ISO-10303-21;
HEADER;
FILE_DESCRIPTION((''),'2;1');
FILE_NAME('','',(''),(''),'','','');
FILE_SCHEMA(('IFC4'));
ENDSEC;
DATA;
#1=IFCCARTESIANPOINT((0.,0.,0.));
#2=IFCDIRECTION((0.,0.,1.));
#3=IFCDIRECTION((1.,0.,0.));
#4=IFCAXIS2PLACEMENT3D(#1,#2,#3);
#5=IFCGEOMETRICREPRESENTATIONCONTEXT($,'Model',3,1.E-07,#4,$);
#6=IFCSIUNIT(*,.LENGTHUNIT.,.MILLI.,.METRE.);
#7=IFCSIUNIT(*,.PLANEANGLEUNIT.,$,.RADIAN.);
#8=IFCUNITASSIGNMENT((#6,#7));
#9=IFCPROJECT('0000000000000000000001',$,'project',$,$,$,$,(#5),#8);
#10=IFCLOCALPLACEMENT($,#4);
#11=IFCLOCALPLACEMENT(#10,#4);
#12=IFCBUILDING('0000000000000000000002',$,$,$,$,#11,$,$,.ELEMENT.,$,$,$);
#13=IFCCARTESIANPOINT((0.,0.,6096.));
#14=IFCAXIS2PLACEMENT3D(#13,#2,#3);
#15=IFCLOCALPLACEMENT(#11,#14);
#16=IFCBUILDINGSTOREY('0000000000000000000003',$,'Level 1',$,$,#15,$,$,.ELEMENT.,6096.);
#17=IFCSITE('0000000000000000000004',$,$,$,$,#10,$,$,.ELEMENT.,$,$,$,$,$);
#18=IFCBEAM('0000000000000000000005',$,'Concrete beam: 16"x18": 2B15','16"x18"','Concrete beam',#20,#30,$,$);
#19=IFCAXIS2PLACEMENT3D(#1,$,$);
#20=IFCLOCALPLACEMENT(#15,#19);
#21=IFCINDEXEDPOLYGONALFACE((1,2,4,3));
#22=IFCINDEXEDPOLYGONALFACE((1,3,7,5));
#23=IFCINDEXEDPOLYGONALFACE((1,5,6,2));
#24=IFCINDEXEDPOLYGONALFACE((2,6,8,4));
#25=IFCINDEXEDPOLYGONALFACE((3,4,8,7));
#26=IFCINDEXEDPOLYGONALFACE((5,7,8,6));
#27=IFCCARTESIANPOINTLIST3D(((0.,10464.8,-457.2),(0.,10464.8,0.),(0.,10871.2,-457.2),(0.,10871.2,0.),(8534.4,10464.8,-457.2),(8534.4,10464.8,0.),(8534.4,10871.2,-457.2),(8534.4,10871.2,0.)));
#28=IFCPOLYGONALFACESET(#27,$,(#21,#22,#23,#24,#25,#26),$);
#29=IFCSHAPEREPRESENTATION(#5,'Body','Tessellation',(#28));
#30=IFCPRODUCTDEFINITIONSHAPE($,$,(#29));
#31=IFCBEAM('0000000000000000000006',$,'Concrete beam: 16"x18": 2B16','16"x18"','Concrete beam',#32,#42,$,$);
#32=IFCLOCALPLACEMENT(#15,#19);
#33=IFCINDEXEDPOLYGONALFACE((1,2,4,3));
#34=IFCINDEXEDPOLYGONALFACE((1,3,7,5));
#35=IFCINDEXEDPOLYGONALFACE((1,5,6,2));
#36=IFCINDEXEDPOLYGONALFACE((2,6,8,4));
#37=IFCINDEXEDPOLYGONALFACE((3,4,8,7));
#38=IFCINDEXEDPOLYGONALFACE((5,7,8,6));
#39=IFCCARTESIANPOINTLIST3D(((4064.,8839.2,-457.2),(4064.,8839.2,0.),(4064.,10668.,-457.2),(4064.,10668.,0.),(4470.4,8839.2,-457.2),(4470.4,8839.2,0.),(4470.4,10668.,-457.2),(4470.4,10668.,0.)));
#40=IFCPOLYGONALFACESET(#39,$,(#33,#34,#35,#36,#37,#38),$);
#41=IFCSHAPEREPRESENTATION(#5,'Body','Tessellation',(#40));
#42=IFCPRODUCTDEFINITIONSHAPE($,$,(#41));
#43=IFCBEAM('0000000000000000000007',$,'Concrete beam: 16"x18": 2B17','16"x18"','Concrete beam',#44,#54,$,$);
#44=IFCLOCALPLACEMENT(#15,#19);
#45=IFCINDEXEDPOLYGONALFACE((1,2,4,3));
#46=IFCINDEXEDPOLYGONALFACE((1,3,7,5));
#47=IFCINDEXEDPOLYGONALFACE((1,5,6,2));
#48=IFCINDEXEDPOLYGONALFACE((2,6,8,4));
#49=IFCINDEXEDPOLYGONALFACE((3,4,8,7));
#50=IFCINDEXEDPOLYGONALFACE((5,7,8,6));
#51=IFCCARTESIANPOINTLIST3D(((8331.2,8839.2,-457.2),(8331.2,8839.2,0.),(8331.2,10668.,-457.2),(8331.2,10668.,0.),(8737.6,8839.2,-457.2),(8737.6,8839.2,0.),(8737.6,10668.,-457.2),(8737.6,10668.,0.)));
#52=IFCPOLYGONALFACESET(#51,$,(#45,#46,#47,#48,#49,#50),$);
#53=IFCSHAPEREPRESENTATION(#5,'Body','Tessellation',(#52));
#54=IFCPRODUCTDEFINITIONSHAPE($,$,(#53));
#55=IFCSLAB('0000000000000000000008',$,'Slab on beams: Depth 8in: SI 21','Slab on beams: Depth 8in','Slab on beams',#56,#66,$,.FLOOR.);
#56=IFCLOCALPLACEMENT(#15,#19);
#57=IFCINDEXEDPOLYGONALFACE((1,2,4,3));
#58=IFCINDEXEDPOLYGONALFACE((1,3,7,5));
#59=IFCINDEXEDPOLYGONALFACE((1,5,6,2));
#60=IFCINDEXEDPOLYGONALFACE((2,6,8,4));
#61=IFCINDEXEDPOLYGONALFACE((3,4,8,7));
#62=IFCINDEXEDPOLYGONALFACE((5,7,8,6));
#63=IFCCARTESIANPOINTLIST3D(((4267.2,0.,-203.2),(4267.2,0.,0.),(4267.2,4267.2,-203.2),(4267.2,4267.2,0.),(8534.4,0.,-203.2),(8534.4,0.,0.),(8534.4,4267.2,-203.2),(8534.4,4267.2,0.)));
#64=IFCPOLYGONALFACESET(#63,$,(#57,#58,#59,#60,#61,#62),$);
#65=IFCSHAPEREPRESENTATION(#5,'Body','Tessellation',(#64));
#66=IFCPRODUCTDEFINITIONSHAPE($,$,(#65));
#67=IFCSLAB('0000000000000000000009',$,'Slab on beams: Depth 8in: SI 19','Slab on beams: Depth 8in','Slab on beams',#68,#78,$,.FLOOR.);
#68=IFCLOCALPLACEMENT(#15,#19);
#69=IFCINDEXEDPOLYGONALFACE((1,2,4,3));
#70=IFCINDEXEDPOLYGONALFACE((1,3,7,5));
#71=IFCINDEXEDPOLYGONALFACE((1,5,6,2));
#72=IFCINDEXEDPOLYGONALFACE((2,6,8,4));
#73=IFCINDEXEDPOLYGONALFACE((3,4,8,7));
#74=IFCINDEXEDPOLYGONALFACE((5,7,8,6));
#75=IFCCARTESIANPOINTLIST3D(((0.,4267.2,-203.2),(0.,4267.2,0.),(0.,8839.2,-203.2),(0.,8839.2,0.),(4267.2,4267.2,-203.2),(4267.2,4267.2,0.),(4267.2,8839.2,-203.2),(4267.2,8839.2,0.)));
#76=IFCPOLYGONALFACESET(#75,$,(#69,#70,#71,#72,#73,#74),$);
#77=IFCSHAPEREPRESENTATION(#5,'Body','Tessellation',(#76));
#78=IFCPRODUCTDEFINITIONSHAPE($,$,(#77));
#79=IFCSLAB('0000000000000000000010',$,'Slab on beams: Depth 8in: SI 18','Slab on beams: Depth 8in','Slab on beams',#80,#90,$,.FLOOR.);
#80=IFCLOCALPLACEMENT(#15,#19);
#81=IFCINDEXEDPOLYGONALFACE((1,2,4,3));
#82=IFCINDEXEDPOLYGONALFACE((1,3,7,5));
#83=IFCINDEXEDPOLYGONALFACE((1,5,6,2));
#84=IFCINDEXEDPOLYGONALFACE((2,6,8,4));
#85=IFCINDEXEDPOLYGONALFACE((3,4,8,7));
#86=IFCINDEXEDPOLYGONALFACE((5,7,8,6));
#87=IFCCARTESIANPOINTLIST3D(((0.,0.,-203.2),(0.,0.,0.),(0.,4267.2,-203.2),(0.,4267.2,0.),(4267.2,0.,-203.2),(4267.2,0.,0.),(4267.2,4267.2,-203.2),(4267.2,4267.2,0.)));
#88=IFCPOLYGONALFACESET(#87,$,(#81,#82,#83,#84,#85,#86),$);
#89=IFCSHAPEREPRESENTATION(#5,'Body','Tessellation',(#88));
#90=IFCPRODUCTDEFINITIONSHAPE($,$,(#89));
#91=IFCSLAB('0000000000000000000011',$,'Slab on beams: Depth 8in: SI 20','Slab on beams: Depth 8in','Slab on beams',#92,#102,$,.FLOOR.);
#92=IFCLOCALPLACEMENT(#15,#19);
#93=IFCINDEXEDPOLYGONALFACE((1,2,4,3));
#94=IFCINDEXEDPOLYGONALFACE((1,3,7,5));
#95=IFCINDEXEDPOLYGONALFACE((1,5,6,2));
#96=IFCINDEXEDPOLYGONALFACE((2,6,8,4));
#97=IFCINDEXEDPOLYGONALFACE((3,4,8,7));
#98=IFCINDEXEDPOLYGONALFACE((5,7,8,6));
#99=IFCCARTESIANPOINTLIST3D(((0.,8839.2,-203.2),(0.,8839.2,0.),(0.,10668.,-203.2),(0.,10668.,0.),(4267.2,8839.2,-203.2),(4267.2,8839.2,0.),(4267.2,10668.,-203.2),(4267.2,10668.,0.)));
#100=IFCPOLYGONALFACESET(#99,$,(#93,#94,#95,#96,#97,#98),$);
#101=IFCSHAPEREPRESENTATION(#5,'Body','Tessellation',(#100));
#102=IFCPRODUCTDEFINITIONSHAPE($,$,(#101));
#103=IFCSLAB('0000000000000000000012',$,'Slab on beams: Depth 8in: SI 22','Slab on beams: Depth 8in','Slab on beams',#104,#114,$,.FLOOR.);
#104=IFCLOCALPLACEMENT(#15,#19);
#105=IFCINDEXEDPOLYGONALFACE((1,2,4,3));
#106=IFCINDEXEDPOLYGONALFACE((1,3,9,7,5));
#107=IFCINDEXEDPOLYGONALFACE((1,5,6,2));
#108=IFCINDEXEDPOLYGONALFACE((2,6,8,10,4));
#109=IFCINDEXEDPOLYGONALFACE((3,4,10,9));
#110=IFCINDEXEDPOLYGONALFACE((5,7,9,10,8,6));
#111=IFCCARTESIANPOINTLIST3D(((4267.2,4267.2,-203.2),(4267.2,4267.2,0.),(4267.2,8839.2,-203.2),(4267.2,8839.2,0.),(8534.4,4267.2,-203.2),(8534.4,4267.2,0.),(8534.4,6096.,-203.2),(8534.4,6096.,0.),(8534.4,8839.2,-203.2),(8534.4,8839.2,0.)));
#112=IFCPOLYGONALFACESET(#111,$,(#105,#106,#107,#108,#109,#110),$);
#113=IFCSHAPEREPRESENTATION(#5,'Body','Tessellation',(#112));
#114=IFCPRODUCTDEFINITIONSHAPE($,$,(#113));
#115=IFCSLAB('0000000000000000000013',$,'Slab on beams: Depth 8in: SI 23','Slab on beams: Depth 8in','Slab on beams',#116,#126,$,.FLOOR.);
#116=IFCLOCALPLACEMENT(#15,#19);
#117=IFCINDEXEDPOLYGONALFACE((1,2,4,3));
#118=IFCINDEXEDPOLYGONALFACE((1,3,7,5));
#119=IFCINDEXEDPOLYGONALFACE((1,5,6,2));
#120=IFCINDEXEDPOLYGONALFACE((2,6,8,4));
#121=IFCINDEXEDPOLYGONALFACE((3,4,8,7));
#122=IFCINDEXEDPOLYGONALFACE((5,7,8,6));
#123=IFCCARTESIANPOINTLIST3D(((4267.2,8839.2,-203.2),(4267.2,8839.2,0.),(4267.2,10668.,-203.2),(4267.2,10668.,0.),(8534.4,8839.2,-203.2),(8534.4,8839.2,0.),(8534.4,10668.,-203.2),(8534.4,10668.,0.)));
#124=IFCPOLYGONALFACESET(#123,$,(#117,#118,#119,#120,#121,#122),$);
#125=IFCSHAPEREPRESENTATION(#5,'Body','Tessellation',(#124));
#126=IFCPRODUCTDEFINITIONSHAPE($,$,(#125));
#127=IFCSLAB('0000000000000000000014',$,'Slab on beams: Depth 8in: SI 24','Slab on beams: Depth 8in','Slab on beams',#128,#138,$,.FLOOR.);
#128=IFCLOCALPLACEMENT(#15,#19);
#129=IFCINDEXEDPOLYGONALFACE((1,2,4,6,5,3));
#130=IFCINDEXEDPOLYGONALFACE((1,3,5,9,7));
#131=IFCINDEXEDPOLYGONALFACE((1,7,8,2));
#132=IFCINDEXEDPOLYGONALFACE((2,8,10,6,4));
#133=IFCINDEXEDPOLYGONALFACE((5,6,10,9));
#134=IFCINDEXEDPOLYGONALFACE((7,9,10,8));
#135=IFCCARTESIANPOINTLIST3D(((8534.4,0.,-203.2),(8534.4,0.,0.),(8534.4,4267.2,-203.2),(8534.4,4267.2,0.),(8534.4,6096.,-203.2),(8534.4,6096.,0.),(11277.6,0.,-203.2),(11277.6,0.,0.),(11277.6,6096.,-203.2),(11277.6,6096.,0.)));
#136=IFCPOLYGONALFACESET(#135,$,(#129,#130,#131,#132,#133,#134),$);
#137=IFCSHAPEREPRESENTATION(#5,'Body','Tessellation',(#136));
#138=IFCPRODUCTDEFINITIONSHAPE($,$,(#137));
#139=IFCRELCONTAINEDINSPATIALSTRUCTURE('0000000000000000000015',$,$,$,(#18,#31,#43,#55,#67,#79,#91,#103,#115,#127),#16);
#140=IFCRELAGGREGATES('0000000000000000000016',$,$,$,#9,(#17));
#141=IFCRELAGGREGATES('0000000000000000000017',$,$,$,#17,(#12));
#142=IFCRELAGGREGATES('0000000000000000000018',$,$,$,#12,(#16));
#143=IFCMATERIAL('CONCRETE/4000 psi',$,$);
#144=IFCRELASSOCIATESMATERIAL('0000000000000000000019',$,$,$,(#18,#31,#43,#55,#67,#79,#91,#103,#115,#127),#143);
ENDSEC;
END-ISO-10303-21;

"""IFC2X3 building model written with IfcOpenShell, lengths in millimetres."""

from ifc_helpers import new_model, si_unit, frame, origin_with_axes, origin_2d_with_axis, place, context, project, spatial, polyline, segment, composite_curve, rectangle, outline, extrude, material, element, save


model = new_model("IFC2X3")

# Units and contexts
model_context = context("Model", 3, precision=1e-07, world=origin_with_axes())
ifc_project = project(units=[si_unit("LENGTHUNIT", "METRE", prefix="MILLI"), si_unit("PLANEANGLEUNIT", "RADIAN")], contexts=[model_context])

# Site, building, storey
site_placement = place(None, origin_with_axes())
site = spatial("IfcSite", under=ifc_project, at=site_placement, CompositionType="ELEMENT")
building_placement = place(site_placement, origin_with_axes())
building = spatial("IfcBuilding", under=site, at=building_placement, CompositionType="ELEMENT")
storey_placement = place(building_placement, frame((0.0, 0.0, 6096.0), z_axis=(0.0, 0.0, 1.0), x_axis=(1.0, 0.0, 0.0)))
storey = spatial("IfcBuildingStorey", under=building, at=storey_placement, Name="Level 1", CompositionType="ELEMENT", Elevation=6096.0)

# Beams
ifc_material = material(Name="CONCRETE/4000 psi")
beam_1_placement = place(building_placement, frame((0.0, 10668.0, 6096.0), z_axis=(0.0, 0.0, 1.0), x_axis=(1.0, 0.0, 0.0)))
element("IfcBeam", 1, at=beam_1_placement, inside=storey, material=ifc_material, Name="Concrete beam: 16\"x18\": 2B15", Description="16\"x18\"", ObjectType="Concrete beam", context=model_context, shape_type="SweptSolid", body=[
    extrude(rectangle(XDim=406.4, YDim=457.2, at=origin_2d_with_axis()), frame((8534.4, 0.0, -228.6), z_axis=(-1.0, 0.0, 0.0), x_axis=(0.0, -1.0, 0.0)), (0.0, 0.0, 1.0), 8534.4),
])
for number, where, z_axis, x_axis, name in (
    (2, (4267.2, 10668.0, 6096.0), (0.0, 0.0, 1.0), (0.0, -1.0, 0.0), "Concrete beam: 16\"x18\": 2B16"),
    (3, (8534.4, 10668.0, 6096.0), (0.0, 0.0, 1.0), (0.0, -1.0, 0.0), "Concrete beam: 16\"x18\": 2B17"),
):
    element("IfcBeam", number, at=place(building_placement, frame(where, z_axis=z_axis, x_axis=x_axis)), inside=storey, material=ifc_material, Name=name, Description="16\"x18\"", ObjectType="Concrete beam", context=model_context, shape_type="SweptSolid", body=[
        extrude(rectangle(XDim=406.4, YDim=457.2, at=origin_2d_with_axis()), frame((1828.8, 0.0, -228.6), z_axis=(-1.0, 0.0, 0.0), x_axis=(0.0, -1.0, 0.0)), (0.0, 0.0, 1.0), 1828.8),
    ])

# Slabs
slab_1_placement = place(building_placement, frame((0.0, 0.0, 6096.0), z_axis=(0.0, 0.0, 1.0), x_axis=(1.0, 0.0, 0.0)))
element("IfcSlab", 4, at=slab_1_placement, inside=storey, material=ifc_material, Name="Slab on beams: Depth 8in: SI 21", Description="Slab on beams: Depth 8in", ObjectType="Slab on beams", PredefinedType="FLOOR", context=model_context, shape_type="SweptSolid", body=[
    extrude(outline(composite_curve([segment(polyline([(4267.2, 4267.2), (4267.2, 0.0)]), True, "CONTINUOUS"), segment(polyline([(4267.2, 0.0), (8534.4, 0.0)]), True, "CONTINUOUS"), segment(polyline([(8534.4, 0.0), (8534.4, 4267.2)]), True, "CONTINUOUS"), segment(polyline([(8534.4, 4267.2), (4267.2, 4267.2)]), True, "CONTINUOUS")], self_intersect=False)), frame((0.0, 0.0, -203.2), z_axis=(0.0, 0.0, 1.0), x_axis=(1.0, 0.0, 0.0)), (0.0, 0.0, 1.0), 203.2),
])
slab_2_placement = place(building_placement, frame((0.0, 0.0, 6096.0), z_axis=(0.0, 0.0, 1.0), x_axis=(1.0, 0.0, 0.0)))
element("IfcSlab", 5, at=slab_2_placement, inside=storey, material=ifc_material, Name="Slab on beams: Depth 8in: SI 19", Description="Slab on beams: Depth 8in", ObjectType="Slab on beams", PredefinedType="FLOOR", context=model_context, shape_type="SweptSolid", body=[
    extrude(outline(composite_curve([segment(polyline([(0.0, 8839.2), (0.0, 4267.2)]), True, "CONTINUOUS"), segment(polyline([(0.0, 4267.2), (4267.2, 4267.2)]), True, "CONTINUOUS"), segment(polyline([(4267.2, 4267.2), (4267.2, 8839.2)]), True, "CONTINUOUS"), segment(polyline([(4267.2, 8839.2), (0.0, 8839.2)]), True, "CONTINUOUS")], self_intersect=False)), frame((0.0, 0.0, -203.2), z_axis=(0.0, 0.0, 1.0), x_axis=(1.0, 0.0, 0.0)), (0.0, 0.0, 1.0), 203.2),
])
slab_3_placement = place(building_placement, frame((0.0, 0.0, 6096.0), z_axis=(0.0, 0.0, 1.0), x_axis=(1.0, 0.0, 0.0)))
element("IfcSlab", 6, at=slab_3_placement, inside=storey, material=ifc_material, Name="Slab on beams: Depth 8in: SI 18", Description="Slab on beams: Depth 8in", ObjectType="Slab on beams", PredefinedType="FLOOR", context=model_context, shape_type="SweptSolid", body=[
    extrude(outline(composite_curve([segment(polyline([(0.0, 4267.2), (0.0, 0.0)]), True, "CONTINUOUS"), segment(polyline([(0.0, 0.0), (4267.2, 0.0)]), True, "CONTINUOUS"), segment(polyline([(4267.2, 0.0), (4267.2, 4267.2)]), True, "CONTINUOUS"), segment(polyline([(4267.2, 4267.2), (0.0, 4267.2)]), True, "CONTINUOUS")], self_intersect=False)), frame((0.0, 0.0, -203.2), z_axis=(0.0, 0.0, 1.0), x_axis=(1.0, 0.0, 0.0)), (0.0, 0.0, 1.0), 203.2),
])
slab_4_placement = place(building_placement, frame((0.0, 0.0, 6096.0), z_axis=(0.0, 0.0, 1.0), x_axis=(1.0, 0.0, 0.0)))
element("IfcSlab", 7, at=slab_4_placement, inside=storey, material=ifc_material, Name="Slab on beams: Depth 8in: SI 20", Description="Slab on beams: Depth 8in", ObjectType="Slab on beams", PredefinedType="FLOOR", context=model_context, shape_type="SweptSolid", body=[
    extrude(outline(composite_curve([segment(polyline([(0.0, 10668.0), (0.0, 8839.2)]), True, "CONTINUOUS"), segment(polyline([(0.0, 8839.2), (4267.2, 8839.2)]), True, "CONTINUOUS"), segment(polyline([(4267.2, 8839.2), (4267.2, 10668.0)]), True, "CONTINUOUS"), segment(polyline([(4267.2, 10668.0), (0.0, 10668.0)]), True, "CONTINUOUS")], self_intersect=False)), frame((0.0, 0.0, -203.2), z_axis=(0.0, 0.0, 1.0), x_axis=(1.0, 0.0, 0.0)), (0.0, 0.0, 1.0), 203.2),
])
slab_5_placement = place(building_placement, frame((0.0, 0.0, 6096.0), z_axis=(0.0, 0.0, 1.0), x_axis=(1.0, 0.0, 0.0)))
element("IfcSlab", 8, at=slab_5_placement, inside=storey, material=ifc_material, Name="Slab on beams: Depth 8in: SI 22", Description="Slab on beams: Depth 8in", ObjectType="Slab on beams", PredefinedType="FLOOR", context=model_context, shape_type="SweptSolid", body=[
    extrude(outline(composite_curve([segment(polyline([(4267.2, 8839.2), (4267.2, 4267.2)]), True, "CONTINUOUS"), segment(polyline([(4267.2, 4267.2), (8534.4, 4267.2)]), True, "CONTINUOUS"), segment(polyline([(8534.4, 4267.2), (8534.4, 6096.0)]), True, "CONTINUOUS"), segment(polyline([(8534.4, 6096.0), (8534.4, 8839.2)]), True, "CONTINUOUS"), segment(polyline([(8534.4, 8839.2), (4267.2, 8839.2)]), True, "CONTINUOUS")], self_intersect=False)), frame((0.0, 0.0, -203.2), z_axis=(0.0, 0.0, 1.0), x_axis=(1.0, 0.0, 0.0)), (0.0, 0.0, 1.0), 203.2),
])
slab_6_placement = place(building_placement, frame((0.0, 0.0, 6096.0), z_axis=(0.0, 0.0, 1.0), x_axis=(1.0, 0.0, 0.0)))
element("IfcSlab", 9, at=slab_6_placement, inside=storey, material=ifc_material, Name="Slab on beams: Depth 8in: SI 23", Description="Slab on beams: Depth 8in", ObjectType="Slab on beams", PredefinedType="FLOOR", context=model_context, shape_type="SweptSolid", body=[
    extrude(outline(composite_curve([segment(polyline([(4267.2, 10668.0), (4267.2, 8839.2)]), True, "CONTINUOUS"), segment(polyline([(4267.2, 8839.2), (8534.4, 8839.2)]), True, "CONTINUOUS"), segment(polyline([(8534.4, 8839.2), (8534.4, 10668.0)]), True, "CONTINUOUS"), segment(polyline([(8534.4, 10668.0), (4267.2, 10668.0)]), True, "CONTINUOUS")], self_intersect=False)), frame((0.0, 0.0, -203.2), z_axis=(0.0, 0.0, 1.0), x_axis=(1.0, 0.0, 0.0)), (0.0, 0.0, 1.0), 203.2),
])
slab_7_placement = place(building_placement, frame((0.0, 0.0, 6096.0), z_axis=(0.0, 0.0, 1.0), x_axis=(1.0, 0.0, 0.0)))
element("IfcSlab", 10, at=slab_7_placement, inside=storey, material=ifc_material, Name="Slab on beams: Depth 8in: SI 24", Description="Slab on beams: Depth 8in", ObjectType="Slab on beams", PredefinedType="FLOOR", context=model_context, shape_type="SweptSolid", body=[
    extrude(outline(composite_curve([segment(polyline([(8534.4, 6096.0), (8534.4, 4267.2)]), True, "CONTINUOUS"), segment(polyline([(8534.4, 4267.2), (8534.4, 0.0)]), True, "CONTINUOUS"), segment(polyline([(8534.4, 0.0), (11277.6, 0.0)]), True, "CONTINUOUS"), segment(polyline([(11277.6, 0.0), (11277.6, 6096.0)]), True, "CONTINUOUS"), segment(polyline([(11277.6, 6096.0), (8534.4, 6096.0)]), True, "CONTINUOUS")], self_intersect=False)), frame((0.0, 0.0, -203.2), z_axis=(0.0, 0.0, 1.0), x_axis=(1.0, 0.0, 0.0)), (0.0, 0.0, 1.0), 203.2),
])

save(model, "model.ifc")
